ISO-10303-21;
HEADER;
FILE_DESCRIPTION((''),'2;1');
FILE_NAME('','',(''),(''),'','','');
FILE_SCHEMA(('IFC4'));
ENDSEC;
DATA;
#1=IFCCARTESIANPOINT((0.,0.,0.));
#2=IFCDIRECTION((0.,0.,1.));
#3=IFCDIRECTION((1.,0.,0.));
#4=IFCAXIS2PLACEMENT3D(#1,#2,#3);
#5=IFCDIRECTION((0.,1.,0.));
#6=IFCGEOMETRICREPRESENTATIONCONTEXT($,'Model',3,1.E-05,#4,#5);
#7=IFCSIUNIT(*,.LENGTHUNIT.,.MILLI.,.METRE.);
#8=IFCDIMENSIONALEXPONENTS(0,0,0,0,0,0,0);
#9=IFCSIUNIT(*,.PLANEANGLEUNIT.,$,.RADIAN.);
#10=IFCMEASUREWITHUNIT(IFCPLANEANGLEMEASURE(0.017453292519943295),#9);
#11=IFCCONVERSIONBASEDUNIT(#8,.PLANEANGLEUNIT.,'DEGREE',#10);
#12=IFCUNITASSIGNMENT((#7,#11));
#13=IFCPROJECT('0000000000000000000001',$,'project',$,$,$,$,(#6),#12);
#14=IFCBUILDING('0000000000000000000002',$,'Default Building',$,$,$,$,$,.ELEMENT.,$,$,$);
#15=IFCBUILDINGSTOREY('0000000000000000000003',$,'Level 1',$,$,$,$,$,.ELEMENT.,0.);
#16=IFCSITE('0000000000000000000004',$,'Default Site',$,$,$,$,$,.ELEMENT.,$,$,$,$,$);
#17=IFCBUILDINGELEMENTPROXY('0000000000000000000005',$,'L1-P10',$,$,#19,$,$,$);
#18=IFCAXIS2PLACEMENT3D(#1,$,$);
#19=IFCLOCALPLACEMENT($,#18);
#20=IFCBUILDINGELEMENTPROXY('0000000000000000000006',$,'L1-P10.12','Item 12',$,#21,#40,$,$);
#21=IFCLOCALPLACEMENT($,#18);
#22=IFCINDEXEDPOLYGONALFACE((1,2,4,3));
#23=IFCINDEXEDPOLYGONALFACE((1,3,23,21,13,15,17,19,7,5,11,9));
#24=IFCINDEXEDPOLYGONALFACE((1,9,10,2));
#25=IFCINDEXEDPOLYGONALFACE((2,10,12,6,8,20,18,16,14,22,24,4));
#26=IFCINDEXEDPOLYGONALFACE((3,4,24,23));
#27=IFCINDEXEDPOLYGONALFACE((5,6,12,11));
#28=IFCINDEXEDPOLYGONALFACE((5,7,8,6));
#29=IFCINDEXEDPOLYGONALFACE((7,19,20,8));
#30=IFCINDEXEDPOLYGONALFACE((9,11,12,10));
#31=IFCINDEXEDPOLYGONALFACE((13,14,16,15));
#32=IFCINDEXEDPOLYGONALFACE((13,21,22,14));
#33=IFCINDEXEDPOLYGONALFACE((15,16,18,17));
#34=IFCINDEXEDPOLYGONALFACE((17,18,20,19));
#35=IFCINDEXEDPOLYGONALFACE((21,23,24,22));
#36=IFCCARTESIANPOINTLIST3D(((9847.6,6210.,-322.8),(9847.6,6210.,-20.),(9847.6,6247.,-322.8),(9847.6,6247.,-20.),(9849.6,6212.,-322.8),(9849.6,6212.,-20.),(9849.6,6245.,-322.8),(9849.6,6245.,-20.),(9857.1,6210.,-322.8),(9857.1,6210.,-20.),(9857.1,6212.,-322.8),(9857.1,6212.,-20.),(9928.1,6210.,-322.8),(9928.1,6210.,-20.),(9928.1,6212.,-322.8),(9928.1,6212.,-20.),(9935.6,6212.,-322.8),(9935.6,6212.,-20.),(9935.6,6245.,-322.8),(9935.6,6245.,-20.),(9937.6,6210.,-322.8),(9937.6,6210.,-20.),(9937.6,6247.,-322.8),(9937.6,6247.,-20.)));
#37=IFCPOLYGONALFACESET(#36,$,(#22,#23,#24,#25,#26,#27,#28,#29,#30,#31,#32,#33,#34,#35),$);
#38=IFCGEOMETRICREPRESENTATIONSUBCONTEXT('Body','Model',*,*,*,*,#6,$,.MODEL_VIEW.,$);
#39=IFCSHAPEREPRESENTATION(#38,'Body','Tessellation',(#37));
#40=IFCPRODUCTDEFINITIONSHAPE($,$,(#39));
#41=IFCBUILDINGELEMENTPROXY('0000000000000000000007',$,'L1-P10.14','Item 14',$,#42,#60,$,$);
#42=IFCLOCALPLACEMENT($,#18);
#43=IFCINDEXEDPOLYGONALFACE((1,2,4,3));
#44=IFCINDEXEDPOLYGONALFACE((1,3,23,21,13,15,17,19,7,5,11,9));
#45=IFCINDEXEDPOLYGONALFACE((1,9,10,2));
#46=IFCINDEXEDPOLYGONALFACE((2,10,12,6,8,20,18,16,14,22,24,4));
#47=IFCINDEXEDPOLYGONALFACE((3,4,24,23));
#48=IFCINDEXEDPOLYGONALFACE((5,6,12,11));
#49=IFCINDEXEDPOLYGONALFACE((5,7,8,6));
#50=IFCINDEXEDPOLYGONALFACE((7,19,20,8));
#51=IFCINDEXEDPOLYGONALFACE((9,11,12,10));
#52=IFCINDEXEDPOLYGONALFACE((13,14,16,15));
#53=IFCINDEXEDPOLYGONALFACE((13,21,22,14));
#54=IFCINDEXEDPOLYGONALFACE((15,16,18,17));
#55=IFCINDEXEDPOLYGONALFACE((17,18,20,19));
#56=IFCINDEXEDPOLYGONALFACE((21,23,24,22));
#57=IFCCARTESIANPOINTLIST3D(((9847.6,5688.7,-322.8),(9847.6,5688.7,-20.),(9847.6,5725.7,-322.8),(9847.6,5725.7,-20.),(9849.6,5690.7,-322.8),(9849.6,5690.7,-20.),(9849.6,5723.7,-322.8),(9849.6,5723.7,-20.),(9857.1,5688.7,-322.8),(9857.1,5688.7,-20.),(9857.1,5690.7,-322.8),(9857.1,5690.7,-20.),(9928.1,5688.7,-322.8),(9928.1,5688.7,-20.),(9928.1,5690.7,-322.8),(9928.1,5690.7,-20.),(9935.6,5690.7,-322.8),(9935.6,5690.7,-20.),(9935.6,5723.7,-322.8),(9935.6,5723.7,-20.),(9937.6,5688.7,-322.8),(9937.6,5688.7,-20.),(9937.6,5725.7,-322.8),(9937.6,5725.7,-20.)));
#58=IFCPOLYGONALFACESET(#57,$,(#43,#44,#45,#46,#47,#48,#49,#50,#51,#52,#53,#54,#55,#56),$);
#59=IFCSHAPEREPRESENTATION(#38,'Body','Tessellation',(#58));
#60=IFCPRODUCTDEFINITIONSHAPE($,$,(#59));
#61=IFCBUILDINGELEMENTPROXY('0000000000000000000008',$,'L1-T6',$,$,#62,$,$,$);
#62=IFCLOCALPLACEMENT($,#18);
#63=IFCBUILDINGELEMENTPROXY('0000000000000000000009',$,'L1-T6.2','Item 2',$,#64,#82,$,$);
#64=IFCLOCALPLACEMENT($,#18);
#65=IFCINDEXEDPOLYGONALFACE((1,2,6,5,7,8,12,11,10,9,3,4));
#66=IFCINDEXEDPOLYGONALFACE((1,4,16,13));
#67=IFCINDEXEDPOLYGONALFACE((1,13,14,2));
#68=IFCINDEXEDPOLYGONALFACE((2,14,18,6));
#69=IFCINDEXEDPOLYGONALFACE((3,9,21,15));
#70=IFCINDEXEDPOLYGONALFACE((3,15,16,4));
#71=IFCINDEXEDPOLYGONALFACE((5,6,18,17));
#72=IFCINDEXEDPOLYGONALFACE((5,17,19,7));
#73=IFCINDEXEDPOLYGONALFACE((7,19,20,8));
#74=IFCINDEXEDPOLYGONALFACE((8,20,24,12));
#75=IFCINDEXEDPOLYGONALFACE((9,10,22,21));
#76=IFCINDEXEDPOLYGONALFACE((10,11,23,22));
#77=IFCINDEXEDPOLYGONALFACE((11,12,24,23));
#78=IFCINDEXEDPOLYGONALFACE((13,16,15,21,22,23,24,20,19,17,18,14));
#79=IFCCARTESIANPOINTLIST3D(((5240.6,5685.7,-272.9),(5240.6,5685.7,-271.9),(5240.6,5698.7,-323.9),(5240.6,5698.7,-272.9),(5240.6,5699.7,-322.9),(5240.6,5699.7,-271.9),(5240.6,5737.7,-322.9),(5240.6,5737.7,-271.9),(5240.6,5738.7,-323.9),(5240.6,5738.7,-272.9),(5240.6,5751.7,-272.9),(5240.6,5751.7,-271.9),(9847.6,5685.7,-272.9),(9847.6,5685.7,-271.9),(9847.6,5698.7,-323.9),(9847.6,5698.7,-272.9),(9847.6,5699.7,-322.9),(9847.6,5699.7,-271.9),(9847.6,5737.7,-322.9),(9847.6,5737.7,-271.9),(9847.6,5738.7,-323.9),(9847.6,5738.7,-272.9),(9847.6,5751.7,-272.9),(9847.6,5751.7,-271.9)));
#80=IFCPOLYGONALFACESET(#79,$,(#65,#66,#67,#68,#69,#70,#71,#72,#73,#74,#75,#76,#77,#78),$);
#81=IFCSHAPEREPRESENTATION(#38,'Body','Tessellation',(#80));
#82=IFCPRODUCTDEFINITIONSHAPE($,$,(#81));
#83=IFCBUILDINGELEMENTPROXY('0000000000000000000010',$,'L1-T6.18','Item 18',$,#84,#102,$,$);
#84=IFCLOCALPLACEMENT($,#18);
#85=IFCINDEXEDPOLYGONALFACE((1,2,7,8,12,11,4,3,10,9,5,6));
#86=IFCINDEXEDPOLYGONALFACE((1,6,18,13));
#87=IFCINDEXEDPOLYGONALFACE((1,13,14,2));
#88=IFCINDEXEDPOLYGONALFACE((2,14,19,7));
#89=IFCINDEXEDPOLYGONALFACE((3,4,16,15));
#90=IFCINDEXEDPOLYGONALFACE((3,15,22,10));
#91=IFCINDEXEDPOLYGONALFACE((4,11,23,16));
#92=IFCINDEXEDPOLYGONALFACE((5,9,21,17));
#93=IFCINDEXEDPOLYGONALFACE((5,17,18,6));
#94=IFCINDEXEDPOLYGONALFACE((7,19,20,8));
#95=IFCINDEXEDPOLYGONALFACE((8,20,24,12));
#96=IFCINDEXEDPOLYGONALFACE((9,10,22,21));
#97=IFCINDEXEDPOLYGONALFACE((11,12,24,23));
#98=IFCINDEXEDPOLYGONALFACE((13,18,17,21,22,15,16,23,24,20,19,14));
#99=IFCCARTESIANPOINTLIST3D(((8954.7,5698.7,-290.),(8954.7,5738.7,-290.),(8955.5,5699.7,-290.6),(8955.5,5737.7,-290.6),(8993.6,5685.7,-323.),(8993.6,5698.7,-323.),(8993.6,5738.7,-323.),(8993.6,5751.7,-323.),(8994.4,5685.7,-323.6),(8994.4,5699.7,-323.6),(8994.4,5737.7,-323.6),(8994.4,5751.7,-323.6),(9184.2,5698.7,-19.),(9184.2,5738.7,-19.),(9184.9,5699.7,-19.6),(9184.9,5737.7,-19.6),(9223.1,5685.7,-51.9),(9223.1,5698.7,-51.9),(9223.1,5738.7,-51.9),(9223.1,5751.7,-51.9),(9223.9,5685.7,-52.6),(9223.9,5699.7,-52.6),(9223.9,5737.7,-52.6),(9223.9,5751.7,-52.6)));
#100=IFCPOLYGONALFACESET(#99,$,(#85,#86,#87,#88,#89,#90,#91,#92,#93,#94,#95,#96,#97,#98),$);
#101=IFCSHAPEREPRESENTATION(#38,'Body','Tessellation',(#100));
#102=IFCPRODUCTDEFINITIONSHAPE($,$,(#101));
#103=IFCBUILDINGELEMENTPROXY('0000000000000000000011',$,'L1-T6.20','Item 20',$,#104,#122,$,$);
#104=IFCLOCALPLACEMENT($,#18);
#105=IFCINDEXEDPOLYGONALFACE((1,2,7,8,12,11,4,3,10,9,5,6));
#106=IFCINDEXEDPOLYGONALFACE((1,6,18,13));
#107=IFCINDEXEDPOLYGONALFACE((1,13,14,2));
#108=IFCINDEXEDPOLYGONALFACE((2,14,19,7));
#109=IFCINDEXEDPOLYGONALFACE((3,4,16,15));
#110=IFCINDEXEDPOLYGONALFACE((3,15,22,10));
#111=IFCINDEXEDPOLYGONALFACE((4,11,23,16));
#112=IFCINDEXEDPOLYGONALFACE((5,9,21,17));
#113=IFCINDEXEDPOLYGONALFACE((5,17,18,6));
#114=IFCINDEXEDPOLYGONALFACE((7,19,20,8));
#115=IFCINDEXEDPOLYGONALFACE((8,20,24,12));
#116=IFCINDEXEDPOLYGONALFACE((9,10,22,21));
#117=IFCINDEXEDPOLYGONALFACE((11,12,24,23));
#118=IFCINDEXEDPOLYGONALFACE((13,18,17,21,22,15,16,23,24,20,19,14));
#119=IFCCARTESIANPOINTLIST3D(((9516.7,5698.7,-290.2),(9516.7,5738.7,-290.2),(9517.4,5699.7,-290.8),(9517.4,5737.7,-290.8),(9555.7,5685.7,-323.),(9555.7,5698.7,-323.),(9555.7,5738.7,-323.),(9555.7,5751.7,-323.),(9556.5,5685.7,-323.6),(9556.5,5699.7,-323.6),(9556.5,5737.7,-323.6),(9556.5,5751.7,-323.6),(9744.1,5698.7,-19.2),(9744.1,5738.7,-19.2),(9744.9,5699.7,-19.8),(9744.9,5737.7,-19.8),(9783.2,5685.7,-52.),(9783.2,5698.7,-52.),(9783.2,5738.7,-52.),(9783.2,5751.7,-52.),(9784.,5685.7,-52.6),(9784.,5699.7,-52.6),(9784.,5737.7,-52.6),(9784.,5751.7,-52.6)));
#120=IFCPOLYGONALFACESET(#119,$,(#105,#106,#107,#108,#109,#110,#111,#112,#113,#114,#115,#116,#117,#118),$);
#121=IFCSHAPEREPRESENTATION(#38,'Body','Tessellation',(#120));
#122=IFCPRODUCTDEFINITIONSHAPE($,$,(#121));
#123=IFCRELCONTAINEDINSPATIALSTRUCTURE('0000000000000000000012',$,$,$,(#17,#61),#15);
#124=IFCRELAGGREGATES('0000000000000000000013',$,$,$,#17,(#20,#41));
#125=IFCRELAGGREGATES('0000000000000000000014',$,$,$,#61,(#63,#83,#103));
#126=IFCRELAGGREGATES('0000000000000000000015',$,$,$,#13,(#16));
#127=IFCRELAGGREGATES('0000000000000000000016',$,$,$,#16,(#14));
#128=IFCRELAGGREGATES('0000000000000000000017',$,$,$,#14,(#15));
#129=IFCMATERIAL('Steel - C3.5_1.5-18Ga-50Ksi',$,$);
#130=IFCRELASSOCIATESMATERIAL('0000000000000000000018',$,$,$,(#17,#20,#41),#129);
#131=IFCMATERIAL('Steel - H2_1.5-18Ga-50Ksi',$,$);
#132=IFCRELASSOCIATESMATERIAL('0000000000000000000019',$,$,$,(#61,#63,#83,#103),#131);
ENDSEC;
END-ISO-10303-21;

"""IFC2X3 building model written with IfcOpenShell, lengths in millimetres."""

from ifc_helpers import new_model, entity, si_unit, converted_unit, direction, frame, origin, origin_with_axes, origin_2d_with_axis, place, context, subcontext, project, spatial, polyline, c_section, outline, extrude, material, element, aggregate, save


model = new_model("IFC2X3")

# Units and contexts
model_context = context("Model", 3, precision=1e-05, world=origin_with_axes(), true_north=direction((0.0, 1.0, 0.0)))
body_context = subcontext(model_context, "Body", "Model", "MODEL_VIEW")
ifc_project = project(units=[si_unit("LENGTHUNIT", "METRE", prefix="MILLI"), converted_unit("PLANEANGLEUNIT", "DEGREE", entity("IfcPlaneAngleMeasure", 0.017453292519943295), si_unit("PLANEANGLEUNIT", "RADIAN"), dimensions=[0, 0, 0, 0, 0, 0, 0])], contexts=[model_context])

# Site, building, storey
site = spatial("IfcSite", under=ifc_project, Name="Default Site", CompositionType="ELEMENT")
building = spatial("IfcBuilding", under=site, Name="Default Building", CompositionType="ELEMENT")
storey = spatial("IfcBuildingStorey", under=building, Name="Level 1", CompositionType="ELEMENT", Elevation=0.0)

# Building element proxies
ifc_material_1 = material(Name="Steel - H2_1.5-18Ga-50Ksi")
ifc_material_2 = material(Name="Steel - C3.5_1.5-18Ga-50Ksi")
proxy_1 = element("IfcBuildingElementProxy", 1, inside=storey, material=ifc_material_2, Name="L1-P10")
proxy_2_placement = place(None, frame((9892.6, 6228.5, -322.8), z_axis=(0.0, 0.0, 1.0), x_axis=(0.0, -37.0, 0.0)))
proxy_2 = element("IfcBuildingElementProxy", 2, at=proxy_2_placement, material=ifc_material_2, Name="L1-P10.12", Description="Item 12", context=body_context, shape_type="SweptSolid", body=[
    extrude(c_section(Depth=90.0, Width=37.0, WallThickness=2.0, Girth=9.5, at=origin_2d_with_axis()), origin(), (0.0, 0.0, 1.0), 302.8),
])
proxy_3_placement = place(None, frame((9892.6, 5707.2, -322.8), z_axis=(0.0, 0.0, 1.0), x_axis=(0.0, -37.0, 0.0)))
proxy_3 = element("IfcBuildingElementProxy", 3, at=proxy_3_placement, material=ifc_material_2, Name="L1-P10.14", Description="Item 14", context=body_context, shape_type="SweptSolid", body=[
    extrude(c_section(Depth=90.0, Width=37.0, WallThickness=2.0, Girth=9.5, at=origin_2d_with_axis()), origin(), (0.0, 0.0, 1.0), 302.8),
])
aggregate(proxy_1, [proxy_2, proxy_3])
proxy_4 = element("IfcBuildingElementProxy", 4, inside=storey, material=ifc_material_1, Name="L1-T6")
proxy_5_placement = place(None, frame((9847.6, 5685.7, -271.9), z_axis=(-1.0, 0.0, 0.0), x_axis=(0.0, 40.0, 0.0)))
proxy_5 = element("IfcBuildingElementProxy", 5, at=proxy_5_placement, material=ifc_material_1, Name="L1-T6.2", Description="Item 2", context=body_context, shape_type="SweptSolid", body=[
    extrude(outline(polyline([(0.0, 0.0), (14.0, 0.0), (14.0, 51.0), (52.0, 51.0), (52.0, 0.0), (66.0, 0.0), (66.0, 1.0), (53.0, 1.0), (53.0, 52.0), (13.0, 52.0), (13.0, 1.0), (0.0, 1.0), (0.0, 0.0)])), origin(), (0.0, 0.0, 1.0), 4607.0),
])
proxy_6_placement = place(None, frame((8994.4, 5685.7, -323.6), z_axis=(0.646, 0.0, 0.763), x_axis=(0.0, 40.0, 0.0)))
proxy_6 = element("IfcBuildingElementProxy", 6, at=proxy_6_placement, material=ifc_material_1, Name="L1-T6.18", Description="Item 18", context=body_context, shape_type="SweptSolid", body=[
    extrude(outline(polyline([(0.0, 0.0), (14.0, 0.0), (14.0, 51.0), (52.0, 51.0), (52.0, 0.0), (66.0, 0.0), (66.0, 1.0), (53.0, 1.0), (53.0, 52.0), (13.0, 52.0), (13.0, 1.0), (0.0, 1.0), (0.0, 0.0)])), origin(), (0.0, 0.0, 1.0), 355.1),
])
proxy_7_placement = place(None, frame((9556.5, 5685.7, -323.6), z_axis=(0.643, 0.0, 0.766), x_axis=(0.0, 40.0, 0.0)))
proxy_7 = element("IfcBuildingElementProxy", 7, at=proxy_7_placement, material=ifc_material_1, Name="L1-T6.20", Description="Item 20", context=body_context, shape_type="SweptSolid", body=[
    extrude(outline(polyline([(0.0, 0.0), (14.0, 0.0), (14.0, 51.0), (52.0, 51.0), (52.0, 0.0), (66.0, 0.0), (66.0, 1.0), (53.0, 1.0), (53.0, 52.0), (13.0, 52.0), (13.0, 1.0), (0.0, 1.0), (0.0, 0.0)])), origin(), (0.0, 0.0, 1.0), 353.8),
])
aggregate(proxy_4, [proxy_5, proxy_6, proxy_7])

save(model, "model.ifc")
